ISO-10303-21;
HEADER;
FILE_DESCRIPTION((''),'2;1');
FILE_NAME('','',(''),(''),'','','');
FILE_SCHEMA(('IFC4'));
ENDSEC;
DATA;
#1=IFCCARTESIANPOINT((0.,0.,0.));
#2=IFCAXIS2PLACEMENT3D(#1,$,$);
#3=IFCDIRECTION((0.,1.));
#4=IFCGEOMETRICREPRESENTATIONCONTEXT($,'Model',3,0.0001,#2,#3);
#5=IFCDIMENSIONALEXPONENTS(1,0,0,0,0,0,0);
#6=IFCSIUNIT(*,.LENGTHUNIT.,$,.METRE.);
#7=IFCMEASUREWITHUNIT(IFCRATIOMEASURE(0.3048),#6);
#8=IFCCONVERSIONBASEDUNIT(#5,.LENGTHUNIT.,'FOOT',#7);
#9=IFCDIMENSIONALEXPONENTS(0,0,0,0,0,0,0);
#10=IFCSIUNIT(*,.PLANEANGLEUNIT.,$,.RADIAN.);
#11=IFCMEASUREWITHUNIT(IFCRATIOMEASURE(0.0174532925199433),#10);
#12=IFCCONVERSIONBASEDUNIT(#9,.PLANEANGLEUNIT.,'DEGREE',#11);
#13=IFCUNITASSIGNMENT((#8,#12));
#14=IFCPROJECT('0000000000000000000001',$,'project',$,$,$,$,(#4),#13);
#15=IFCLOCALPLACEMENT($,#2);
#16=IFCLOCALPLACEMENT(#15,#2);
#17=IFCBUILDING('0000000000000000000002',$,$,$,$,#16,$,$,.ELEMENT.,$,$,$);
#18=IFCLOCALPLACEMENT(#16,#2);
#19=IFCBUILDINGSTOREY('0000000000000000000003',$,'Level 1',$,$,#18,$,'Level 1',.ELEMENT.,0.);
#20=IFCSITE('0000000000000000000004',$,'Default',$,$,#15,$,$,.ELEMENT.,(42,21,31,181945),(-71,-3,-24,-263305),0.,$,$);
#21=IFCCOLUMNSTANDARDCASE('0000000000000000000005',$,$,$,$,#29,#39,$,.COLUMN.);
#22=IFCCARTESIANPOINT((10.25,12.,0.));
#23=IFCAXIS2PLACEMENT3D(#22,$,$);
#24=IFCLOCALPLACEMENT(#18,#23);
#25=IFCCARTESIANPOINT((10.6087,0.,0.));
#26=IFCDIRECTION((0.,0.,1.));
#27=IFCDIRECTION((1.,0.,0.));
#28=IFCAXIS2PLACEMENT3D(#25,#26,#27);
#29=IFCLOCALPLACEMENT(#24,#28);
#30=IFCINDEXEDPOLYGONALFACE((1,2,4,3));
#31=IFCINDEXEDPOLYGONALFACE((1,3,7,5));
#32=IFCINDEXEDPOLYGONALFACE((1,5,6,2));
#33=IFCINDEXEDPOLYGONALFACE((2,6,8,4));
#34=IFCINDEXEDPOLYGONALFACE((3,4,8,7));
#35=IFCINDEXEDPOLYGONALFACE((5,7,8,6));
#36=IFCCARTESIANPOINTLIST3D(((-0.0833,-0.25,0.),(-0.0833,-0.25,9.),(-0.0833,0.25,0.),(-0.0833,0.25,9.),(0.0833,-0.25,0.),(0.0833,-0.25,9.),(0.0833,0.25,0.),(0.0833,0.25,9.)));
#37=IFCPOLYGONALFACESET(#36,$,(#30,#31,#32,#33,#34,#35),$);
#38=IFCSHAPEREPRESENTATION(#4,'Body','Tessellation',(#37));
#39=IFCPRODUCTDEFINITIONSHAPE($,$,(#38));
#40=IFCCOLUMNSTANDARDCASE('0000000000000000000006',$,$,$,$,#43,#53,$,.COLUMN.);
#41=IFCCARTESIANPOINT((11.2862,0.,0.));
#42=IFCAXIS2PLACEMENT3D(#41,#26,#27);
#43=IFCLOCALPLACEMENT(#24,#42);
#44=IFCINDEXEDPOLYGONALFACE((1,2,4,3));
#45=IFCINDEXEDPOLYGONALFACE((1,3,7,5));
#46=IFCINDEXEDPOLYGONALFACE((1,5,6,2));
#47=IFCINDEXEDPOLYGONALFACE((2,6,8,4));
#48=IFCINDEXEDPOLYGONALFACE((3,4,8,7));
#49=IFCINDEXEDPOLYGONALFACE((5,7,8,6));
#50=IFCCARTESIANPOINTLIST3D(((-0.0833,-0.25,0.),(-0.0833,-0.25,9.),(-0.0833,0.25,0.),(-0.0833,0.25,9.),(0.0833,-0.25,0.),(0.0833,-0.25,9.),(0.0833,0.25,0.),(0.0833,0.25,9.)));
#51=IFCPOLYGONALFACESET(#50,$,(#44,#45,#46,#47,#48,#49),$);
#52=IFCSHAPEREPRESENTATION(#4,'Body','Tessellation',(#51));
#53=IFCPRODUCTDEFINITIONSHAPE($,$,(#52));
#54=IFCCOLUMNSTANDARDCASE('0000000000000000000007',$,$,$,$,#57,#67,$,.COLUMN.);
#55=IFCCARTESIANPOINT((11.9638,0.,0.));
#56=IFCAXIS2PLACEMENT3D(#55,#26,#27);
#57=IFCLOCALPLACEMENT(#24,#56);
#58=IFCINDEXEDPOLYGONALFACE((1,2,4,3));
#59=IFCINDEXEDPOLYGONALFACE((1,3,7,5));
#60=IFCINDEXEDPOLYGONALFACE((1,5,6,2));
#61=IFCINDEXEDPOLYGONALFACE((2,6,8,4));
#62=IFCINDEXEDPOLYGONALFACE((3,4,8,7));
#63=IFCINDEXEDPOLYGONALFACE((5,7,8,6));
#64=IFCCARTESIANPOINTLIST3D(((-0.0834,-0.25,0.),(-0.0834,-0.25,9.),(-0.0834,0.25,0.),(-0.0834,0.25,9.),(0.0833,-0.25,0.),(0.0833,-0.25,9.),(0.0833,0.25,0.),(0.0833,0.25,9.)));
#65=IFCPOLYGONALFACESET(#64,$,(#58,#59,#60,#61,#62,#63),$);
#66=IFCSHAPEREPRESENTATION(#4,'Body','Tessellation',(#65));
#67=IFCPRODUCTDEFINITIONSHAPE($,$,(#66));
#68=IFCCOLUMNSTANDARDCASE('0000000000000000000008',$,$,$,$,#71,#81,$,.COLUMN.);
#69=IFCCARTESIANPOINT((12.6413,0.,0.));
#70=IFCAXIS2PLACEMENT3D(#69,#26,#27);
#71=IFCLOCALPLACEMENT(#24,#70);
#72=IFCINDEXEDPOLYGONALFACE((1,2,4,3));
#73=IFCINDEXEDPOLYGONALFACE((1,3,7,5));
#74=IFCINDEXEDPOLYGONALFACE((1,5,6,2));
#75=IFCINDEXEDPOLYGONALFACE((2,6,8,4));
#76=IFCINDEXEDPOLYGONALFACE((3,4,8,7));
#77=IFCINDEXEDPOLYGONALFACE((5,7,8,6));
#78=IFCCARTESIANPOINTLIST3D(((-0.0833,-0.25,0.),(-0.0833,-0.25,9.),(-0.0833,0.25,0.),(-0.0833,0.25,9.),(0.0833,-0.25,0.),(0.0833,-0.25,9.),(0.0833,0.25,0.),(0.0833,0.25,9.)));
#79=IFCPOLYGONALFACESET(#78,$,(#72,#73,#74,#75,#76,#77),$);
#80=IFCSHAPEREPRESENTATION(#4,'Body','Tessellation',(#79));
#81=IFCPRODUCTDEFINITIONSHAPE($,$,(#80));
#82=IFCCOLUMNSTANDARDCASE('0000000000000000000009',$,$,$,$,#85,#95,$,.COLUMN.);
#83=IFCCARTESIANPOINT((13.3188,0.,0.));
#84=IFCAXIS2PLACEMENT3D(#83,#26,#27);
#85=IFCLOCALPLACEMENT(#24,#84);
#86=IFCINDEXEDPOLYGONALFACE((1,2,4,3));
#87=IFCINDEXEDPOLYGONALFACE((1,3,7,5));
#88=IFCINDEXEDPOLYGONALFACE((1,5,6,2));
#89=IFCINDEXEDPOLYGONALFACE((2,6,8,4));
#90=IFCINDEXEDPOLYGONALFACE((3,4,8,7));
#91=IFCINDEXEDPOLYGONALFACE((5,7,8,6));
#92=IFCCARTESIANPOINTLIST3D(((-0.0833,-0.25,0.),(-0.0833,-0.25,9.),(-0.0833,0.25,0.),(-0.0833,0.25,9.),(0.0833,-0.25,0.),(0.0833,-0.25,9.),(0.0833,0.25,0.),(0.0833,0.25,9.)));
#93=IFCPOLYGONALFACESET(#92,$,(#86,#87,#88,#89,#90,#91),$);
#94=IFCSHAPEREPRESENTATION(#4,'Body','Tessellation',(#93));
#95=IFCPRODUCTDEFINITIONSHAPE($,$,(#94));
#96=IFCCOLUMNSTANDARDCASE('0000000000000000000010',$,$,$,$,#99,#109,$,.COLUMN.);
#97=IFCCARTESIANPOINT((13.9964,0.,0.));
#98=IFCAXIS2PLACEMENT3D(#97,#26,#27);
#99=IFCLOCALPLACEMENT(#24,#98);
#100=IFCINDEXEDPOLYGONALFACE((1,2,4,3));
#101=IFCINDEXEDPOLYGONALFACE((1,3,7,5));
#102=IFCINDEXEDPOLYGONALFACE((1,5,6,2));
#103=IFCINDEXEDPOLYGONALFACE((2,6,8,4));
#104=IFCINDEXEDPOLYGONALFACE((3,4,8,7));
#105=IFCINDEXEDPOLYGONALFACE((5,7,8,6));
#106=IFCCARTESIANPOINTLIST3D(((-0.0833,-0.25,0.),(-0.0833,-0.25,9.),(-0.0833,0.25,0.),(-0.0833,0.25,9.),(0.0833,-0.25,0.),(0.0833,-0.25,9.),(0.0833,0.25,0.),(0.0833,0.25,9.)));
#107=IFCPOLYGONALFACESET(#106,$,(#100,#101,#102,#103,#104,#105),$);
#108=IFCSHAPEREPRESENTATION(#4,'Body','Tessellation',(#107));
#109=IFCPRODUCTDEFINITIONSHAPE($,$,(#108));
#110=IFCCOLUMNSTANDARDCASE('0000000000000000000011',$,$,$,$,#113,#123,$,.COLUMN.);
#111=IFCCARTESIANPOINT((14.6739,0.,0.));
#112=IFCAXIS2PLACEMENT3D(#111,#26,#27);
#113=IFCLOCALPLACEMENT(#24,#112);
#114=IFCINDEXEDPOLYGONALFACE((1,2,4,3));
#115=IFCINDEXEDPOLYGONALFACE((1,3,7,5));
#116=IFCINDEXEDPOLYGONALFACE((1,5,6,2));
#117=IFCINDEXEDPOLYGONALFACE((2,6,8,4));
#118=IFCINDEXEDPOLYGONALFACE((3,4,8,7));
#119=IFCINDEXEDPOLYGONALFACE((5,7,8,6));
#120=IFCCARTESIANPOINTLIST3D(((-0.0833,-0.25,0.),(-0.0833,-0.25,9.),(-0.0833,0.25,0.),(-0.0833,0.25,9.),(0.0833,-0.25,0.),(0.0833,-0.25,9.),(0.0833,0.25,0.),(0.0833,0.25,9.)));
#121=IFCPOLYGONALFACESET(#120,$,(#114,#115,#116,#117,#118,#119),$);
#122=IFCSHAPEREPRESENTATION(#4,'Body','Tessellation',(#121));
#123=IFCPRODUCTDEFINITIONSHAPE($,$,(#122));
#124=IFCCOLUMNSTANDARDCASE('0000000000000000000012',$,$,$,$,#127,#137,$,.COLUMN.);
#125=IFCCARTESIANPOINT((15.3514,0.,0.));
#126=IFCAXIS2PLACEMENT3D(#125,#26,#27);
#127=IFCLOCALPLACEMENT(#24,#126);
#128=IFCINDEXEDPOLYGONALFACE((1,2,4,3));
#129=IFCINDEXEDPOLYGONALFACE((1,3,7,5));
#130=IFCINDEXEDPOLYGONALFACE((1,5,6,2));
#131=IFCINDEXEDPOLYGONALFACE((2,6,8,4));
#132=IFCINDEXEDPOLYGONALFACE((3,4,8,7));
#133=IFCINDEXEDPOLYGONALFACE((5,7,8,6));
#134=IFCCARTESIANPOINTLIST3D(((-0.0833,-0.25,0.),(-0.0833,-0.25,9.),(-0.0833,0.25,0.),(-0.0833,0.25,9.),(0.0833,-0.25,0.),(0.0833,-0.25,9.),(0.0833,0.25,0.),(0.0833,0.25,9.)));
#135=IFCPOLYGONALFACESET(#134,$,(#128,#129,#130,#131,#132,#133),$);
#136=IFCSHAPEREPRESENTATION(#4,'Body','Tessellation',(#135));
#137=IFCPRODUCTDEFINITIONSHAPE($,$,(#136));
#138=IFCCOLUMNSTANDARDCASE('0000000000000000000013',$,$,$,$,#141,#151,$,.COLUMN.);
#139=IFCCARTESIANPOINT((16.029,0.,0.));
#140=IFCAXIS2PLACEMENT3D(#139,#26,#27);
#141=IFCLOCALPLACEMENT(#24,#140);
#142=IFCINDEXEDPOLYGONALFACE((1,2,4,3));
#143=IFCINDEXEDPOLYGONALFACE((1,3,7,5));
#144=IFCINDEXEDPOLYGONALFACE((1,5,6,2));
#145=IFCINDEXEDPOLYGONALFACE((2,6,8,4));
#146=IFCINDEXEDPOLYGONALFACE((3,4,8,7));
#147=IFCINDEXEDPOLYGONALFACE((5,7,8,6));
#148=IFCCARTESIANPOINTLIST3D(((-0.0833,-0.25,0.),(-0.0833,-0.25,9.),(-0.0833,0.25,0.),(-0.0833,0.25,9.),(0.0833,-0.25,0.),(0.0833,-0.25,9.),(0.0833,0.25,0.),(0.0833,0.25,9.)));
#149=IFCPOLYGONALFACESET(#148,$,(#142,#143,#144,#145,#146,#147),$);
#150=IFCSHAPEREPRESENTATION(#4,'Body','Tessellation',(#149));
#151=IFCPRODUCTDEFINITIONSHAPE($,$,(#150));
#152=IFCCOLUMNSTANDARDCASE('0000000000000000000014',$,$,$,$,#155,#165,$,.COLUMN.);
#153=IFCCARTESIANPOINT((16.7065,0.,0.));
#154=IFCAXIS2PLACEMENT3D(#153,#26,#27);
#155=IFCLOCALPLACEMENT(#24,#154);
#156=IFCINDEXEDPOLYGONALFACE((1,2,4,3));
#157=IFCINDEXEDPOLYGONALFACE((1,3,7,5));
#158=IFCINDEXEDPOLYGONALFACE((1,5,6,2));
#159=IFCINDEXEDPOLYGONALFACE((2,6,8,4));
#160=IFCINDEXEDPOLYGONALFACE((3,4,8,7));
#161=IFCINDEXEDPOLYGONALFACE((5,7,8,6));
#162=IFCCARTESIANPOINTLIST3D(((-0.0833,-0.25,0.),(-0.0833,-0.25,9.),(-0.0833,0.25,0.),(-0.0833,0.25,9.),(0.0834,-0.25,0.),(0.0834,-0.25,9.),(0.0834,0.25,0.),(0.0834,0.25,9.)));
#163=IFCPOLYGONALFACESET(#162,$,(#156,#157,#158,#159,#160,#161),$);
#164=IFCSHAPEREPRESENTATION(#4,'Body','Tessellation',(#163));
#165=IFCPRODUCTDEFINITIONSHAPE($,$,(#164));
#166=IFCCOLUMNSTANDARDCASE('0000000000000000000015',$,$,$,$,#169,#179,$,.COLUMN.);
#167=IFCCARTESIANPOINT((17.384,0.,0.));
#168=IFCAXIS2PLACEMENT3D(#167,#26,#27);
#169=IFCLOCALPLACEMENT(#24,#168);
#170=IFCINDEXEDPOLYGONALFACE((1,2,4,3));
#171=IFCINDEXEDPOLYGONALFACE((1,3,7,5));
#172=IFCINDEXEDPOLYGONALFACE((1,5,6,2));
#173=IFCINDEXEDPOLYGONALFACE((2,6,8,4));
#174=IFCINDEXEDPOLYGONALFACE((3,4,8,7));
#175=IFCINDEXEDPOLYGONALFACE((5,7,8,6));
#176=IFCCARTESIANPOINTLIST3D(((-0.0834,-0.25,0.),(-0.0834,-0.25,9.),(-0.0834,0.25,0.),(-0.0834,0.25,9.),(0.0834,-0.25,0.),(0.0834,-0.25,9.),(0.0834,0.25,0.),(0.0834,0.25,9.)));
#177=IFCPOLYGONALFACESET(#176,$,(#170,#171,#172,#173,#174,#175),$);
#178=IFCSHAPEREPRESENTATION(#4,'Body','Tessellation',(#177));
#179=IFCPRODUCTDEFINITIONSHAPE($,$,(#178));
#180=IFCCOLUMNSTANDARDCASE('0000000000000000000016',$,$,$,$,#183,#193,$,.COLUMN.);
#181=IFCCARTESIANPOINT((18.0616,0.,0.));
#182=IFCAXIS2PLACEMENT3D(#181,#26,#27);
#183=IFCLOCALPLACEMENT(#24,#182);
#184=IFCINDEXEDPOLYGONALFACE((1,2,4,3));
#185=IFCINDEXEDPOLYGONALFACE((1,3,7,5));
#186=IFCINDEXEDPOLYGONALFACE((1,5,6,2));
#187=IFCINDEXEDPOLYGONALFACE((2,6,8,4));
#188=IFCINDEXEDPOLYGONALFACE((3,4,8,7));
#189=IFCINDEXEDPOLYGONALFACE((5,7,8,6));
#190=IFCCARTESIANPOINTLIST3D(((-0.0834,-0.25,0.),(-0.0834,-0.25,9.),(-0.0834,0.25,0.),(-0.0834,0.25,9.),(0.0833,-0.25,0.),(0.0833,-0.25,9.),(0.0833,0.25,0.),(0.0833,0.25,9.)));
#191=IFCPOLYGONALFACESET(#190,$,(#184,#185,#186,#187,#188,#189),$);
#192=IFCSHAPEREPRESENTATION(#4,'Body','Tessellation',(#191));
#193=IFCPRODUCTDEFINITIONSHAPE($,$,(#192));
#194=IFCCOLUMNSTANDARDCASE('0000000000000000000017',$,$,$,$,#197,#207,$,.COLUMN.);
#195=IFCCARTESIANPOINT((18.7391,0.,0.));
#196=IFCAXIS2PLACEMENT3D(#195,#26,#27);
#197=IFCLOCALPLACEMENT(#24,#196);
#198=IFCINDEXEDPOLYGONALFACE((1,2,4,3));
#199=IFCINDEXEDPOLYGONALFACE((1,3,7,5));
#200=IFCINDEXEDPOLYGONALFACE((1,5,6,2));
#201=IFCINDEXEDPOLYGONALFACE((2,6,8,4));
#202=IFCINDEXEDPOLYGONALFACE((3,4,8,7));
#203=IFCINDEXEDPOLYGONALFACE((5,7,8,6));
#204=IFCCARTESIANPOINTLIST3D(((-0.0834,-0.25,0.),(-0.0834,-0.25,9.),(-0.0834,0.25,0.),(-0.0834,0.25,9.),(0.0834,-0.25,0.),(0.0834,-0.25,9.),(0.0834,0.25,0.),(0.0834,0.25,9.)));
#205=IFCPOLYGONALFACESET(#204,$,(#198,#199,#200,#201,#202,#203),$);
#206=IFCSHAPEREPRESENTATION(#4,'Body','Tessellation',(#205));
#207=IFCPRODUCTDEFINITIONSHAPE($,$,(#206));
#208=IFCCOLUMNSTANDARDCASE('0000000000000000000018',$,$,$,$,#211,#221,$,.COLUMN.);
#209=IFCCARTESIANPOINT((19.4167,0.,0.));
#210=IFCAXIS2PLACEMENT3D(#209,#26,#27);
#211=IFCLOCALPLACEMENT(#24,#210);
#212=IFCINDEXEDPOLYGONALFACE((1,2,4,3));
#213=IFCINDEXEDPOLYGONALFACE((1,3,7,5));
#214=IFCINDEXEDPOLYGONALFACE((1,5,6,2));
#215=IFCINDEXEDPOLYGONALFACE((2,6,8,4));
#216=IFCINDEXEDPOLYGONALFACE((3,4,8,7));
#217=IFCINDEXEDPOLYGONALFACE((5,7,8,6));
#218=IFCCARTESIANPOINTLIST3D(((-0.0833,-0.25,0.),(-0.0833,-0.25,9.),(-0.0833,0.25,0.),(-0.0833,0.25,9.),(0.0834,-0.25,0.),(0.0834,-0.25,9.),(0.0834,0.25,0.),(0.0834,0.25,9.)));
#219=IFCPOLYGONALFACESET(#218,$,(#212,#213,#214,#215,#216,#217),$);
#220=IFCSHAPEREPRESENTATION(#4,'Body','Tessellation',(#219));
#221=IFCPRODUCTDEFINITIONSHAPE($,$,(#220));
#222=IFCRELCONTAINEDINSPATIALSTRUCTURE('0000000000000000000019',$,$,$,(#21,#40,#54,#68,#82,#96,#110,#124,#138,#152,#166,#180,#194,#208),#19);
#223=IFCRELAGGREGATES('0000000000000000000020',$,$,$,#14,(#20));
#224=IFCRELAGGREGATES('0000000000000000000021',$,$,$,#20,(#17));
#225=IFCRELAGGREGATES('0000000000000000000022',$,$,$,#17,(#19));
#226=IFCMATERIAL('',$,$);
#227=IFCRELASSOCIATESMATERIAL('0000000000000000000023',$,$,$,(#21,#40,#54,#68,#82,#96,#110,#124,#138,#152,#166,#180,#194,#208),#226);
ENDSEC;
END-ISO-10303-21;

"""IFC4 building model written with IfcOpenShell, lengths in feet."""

from ifc_helpers import new_model, entity, si_unit, converted_unit, direction, frame, origin, place, context, project, spatial, rectangle, extrude, material, element, save


model = new_model("IFC4")

# Units and contexts
model_context = context("Model", 3, precision=0.0001, world=origin(), true_north=direction((0.0, 1.0)))
ifc_project = project(units=[converted_unit("LENGTHUNIT", "FOOT", entity("IfcRatioMeasure", 0.3048), si_unit("LENGTHUNIT", "METRE"), dimensions=[1, 0, 0, 0, 0, 0, 0]), converted_unit("PLANEANGLEUNIT", "DEGREE", entity("IfcRatioMeasure", 0.0174532925199433), si_unit("PLANEANGLEUNIT", "RADIAN"), dimensions=[0, 0, 0, 0, 0, 0, 0])], contexts=[model_context])

# Site, building, storey
site_placement = place(None, origin())
site = spatial("IfcSite", under=ifc_project, at=site_placement, Name="Default", CompositionType="ELEMENT", RefLatitude=(42, 21, 31, 181945), RefLongitude=(-71, -3, -24, -263305), RefElevation=0.0)
building_placement = place(site_placement, origin())
building = spatial("IfcBuilding", under=site, at=building_placement, CompositionType="ELEMENT")
storey_placement = place(building_placement, origin())
storey = spatial("IfcBuildingStorey", under=building, at=storey_placement, Name="Level 1", LongName="Level 1", CompositionType="ELEMENT", Elevation=0.0)

# Columns
ifc_material = material(Name="")
placement_1 = place(storey_placement, frame((10.25, 12.0, 0.0)))
for number, where, z_axis, x_axis in (
    (1, (10.6087, 0.0, 0.0), (0.0, 0.0, 1.0), (1.0, 0.0, 0.0)),
    (2, (11.2862, 0.0, 0.0), (0.0, 0.0, 1.0), (1.0, 0.0, 0.0)),
    (3, (11.9638, 0.0, 0.0), (0.0, 0.0, 1.0), (1.0, 0.0, 0.0)),
    (4, (12.6413, 0.0, 0.0), (0.0, 0.0, 1.0), (1.0, 0.0, 0.0)),
    (5, (13.3188, 0.0, 0.0), (0.0, 0.0, 1.0), (1.0, 0.0, 0.0)),
    (6, (13.9964, 0.0, 0.0), (0.0, 0.0, 1.0), (1.0, 0.0, 0.0)),
    (7, (14.6739, 0.0, 0.0), (0.0, 0.0, 1.0), (1.0, 0.0, 0.0)),
    (8, (15.3514, 0.0, 0.0), (0.0, 0.0, 1.0), (1.0, 0.0, 0.0)),
    (9, (16.029, 0.0, 0.0), (0.0, 0.0, 1.0), (1.0, 0.0, 0.0)),
    (10, (16.7065, 0.0, 0.0), (0.0, 0.0, 1.0), (1.0, 0.0, 0.0)),
    (11, (17.384, 0.0, 0.0), (0.0, 0.0, 1.0), (1.0, 0.0, 0.0)),
    (12, (18.0616, 0.0, 0.0), (0.0, 0.0, 1.0), (1.0, 0.0, 0.0)),
    (13, (18.7391, 0.0, 0.0), (0.0, 0.0, 1.0), (1.0, 0.0, 0.0)),
    (14, (19.4167, 0.0, 0.0), (0.0, 0.0, 1.0), (1.0, 0.0, 0.0)),
):
    element("IfcColumnStandardCase", number, at=place(placement_1, frame(where, z_axis=z_axis, x_axis=x_axis)), inside=storey, material=ifc_material, PredefinedType="COLUMN", context=model_context, shape_type="SweptSolid", body=[
        extrude(rectangle(XDim=0.1667, YDim=0.5), origin(), (0.0, 0.0, 1.0), 9.0),
    ])

save(model, "model.ifc")
